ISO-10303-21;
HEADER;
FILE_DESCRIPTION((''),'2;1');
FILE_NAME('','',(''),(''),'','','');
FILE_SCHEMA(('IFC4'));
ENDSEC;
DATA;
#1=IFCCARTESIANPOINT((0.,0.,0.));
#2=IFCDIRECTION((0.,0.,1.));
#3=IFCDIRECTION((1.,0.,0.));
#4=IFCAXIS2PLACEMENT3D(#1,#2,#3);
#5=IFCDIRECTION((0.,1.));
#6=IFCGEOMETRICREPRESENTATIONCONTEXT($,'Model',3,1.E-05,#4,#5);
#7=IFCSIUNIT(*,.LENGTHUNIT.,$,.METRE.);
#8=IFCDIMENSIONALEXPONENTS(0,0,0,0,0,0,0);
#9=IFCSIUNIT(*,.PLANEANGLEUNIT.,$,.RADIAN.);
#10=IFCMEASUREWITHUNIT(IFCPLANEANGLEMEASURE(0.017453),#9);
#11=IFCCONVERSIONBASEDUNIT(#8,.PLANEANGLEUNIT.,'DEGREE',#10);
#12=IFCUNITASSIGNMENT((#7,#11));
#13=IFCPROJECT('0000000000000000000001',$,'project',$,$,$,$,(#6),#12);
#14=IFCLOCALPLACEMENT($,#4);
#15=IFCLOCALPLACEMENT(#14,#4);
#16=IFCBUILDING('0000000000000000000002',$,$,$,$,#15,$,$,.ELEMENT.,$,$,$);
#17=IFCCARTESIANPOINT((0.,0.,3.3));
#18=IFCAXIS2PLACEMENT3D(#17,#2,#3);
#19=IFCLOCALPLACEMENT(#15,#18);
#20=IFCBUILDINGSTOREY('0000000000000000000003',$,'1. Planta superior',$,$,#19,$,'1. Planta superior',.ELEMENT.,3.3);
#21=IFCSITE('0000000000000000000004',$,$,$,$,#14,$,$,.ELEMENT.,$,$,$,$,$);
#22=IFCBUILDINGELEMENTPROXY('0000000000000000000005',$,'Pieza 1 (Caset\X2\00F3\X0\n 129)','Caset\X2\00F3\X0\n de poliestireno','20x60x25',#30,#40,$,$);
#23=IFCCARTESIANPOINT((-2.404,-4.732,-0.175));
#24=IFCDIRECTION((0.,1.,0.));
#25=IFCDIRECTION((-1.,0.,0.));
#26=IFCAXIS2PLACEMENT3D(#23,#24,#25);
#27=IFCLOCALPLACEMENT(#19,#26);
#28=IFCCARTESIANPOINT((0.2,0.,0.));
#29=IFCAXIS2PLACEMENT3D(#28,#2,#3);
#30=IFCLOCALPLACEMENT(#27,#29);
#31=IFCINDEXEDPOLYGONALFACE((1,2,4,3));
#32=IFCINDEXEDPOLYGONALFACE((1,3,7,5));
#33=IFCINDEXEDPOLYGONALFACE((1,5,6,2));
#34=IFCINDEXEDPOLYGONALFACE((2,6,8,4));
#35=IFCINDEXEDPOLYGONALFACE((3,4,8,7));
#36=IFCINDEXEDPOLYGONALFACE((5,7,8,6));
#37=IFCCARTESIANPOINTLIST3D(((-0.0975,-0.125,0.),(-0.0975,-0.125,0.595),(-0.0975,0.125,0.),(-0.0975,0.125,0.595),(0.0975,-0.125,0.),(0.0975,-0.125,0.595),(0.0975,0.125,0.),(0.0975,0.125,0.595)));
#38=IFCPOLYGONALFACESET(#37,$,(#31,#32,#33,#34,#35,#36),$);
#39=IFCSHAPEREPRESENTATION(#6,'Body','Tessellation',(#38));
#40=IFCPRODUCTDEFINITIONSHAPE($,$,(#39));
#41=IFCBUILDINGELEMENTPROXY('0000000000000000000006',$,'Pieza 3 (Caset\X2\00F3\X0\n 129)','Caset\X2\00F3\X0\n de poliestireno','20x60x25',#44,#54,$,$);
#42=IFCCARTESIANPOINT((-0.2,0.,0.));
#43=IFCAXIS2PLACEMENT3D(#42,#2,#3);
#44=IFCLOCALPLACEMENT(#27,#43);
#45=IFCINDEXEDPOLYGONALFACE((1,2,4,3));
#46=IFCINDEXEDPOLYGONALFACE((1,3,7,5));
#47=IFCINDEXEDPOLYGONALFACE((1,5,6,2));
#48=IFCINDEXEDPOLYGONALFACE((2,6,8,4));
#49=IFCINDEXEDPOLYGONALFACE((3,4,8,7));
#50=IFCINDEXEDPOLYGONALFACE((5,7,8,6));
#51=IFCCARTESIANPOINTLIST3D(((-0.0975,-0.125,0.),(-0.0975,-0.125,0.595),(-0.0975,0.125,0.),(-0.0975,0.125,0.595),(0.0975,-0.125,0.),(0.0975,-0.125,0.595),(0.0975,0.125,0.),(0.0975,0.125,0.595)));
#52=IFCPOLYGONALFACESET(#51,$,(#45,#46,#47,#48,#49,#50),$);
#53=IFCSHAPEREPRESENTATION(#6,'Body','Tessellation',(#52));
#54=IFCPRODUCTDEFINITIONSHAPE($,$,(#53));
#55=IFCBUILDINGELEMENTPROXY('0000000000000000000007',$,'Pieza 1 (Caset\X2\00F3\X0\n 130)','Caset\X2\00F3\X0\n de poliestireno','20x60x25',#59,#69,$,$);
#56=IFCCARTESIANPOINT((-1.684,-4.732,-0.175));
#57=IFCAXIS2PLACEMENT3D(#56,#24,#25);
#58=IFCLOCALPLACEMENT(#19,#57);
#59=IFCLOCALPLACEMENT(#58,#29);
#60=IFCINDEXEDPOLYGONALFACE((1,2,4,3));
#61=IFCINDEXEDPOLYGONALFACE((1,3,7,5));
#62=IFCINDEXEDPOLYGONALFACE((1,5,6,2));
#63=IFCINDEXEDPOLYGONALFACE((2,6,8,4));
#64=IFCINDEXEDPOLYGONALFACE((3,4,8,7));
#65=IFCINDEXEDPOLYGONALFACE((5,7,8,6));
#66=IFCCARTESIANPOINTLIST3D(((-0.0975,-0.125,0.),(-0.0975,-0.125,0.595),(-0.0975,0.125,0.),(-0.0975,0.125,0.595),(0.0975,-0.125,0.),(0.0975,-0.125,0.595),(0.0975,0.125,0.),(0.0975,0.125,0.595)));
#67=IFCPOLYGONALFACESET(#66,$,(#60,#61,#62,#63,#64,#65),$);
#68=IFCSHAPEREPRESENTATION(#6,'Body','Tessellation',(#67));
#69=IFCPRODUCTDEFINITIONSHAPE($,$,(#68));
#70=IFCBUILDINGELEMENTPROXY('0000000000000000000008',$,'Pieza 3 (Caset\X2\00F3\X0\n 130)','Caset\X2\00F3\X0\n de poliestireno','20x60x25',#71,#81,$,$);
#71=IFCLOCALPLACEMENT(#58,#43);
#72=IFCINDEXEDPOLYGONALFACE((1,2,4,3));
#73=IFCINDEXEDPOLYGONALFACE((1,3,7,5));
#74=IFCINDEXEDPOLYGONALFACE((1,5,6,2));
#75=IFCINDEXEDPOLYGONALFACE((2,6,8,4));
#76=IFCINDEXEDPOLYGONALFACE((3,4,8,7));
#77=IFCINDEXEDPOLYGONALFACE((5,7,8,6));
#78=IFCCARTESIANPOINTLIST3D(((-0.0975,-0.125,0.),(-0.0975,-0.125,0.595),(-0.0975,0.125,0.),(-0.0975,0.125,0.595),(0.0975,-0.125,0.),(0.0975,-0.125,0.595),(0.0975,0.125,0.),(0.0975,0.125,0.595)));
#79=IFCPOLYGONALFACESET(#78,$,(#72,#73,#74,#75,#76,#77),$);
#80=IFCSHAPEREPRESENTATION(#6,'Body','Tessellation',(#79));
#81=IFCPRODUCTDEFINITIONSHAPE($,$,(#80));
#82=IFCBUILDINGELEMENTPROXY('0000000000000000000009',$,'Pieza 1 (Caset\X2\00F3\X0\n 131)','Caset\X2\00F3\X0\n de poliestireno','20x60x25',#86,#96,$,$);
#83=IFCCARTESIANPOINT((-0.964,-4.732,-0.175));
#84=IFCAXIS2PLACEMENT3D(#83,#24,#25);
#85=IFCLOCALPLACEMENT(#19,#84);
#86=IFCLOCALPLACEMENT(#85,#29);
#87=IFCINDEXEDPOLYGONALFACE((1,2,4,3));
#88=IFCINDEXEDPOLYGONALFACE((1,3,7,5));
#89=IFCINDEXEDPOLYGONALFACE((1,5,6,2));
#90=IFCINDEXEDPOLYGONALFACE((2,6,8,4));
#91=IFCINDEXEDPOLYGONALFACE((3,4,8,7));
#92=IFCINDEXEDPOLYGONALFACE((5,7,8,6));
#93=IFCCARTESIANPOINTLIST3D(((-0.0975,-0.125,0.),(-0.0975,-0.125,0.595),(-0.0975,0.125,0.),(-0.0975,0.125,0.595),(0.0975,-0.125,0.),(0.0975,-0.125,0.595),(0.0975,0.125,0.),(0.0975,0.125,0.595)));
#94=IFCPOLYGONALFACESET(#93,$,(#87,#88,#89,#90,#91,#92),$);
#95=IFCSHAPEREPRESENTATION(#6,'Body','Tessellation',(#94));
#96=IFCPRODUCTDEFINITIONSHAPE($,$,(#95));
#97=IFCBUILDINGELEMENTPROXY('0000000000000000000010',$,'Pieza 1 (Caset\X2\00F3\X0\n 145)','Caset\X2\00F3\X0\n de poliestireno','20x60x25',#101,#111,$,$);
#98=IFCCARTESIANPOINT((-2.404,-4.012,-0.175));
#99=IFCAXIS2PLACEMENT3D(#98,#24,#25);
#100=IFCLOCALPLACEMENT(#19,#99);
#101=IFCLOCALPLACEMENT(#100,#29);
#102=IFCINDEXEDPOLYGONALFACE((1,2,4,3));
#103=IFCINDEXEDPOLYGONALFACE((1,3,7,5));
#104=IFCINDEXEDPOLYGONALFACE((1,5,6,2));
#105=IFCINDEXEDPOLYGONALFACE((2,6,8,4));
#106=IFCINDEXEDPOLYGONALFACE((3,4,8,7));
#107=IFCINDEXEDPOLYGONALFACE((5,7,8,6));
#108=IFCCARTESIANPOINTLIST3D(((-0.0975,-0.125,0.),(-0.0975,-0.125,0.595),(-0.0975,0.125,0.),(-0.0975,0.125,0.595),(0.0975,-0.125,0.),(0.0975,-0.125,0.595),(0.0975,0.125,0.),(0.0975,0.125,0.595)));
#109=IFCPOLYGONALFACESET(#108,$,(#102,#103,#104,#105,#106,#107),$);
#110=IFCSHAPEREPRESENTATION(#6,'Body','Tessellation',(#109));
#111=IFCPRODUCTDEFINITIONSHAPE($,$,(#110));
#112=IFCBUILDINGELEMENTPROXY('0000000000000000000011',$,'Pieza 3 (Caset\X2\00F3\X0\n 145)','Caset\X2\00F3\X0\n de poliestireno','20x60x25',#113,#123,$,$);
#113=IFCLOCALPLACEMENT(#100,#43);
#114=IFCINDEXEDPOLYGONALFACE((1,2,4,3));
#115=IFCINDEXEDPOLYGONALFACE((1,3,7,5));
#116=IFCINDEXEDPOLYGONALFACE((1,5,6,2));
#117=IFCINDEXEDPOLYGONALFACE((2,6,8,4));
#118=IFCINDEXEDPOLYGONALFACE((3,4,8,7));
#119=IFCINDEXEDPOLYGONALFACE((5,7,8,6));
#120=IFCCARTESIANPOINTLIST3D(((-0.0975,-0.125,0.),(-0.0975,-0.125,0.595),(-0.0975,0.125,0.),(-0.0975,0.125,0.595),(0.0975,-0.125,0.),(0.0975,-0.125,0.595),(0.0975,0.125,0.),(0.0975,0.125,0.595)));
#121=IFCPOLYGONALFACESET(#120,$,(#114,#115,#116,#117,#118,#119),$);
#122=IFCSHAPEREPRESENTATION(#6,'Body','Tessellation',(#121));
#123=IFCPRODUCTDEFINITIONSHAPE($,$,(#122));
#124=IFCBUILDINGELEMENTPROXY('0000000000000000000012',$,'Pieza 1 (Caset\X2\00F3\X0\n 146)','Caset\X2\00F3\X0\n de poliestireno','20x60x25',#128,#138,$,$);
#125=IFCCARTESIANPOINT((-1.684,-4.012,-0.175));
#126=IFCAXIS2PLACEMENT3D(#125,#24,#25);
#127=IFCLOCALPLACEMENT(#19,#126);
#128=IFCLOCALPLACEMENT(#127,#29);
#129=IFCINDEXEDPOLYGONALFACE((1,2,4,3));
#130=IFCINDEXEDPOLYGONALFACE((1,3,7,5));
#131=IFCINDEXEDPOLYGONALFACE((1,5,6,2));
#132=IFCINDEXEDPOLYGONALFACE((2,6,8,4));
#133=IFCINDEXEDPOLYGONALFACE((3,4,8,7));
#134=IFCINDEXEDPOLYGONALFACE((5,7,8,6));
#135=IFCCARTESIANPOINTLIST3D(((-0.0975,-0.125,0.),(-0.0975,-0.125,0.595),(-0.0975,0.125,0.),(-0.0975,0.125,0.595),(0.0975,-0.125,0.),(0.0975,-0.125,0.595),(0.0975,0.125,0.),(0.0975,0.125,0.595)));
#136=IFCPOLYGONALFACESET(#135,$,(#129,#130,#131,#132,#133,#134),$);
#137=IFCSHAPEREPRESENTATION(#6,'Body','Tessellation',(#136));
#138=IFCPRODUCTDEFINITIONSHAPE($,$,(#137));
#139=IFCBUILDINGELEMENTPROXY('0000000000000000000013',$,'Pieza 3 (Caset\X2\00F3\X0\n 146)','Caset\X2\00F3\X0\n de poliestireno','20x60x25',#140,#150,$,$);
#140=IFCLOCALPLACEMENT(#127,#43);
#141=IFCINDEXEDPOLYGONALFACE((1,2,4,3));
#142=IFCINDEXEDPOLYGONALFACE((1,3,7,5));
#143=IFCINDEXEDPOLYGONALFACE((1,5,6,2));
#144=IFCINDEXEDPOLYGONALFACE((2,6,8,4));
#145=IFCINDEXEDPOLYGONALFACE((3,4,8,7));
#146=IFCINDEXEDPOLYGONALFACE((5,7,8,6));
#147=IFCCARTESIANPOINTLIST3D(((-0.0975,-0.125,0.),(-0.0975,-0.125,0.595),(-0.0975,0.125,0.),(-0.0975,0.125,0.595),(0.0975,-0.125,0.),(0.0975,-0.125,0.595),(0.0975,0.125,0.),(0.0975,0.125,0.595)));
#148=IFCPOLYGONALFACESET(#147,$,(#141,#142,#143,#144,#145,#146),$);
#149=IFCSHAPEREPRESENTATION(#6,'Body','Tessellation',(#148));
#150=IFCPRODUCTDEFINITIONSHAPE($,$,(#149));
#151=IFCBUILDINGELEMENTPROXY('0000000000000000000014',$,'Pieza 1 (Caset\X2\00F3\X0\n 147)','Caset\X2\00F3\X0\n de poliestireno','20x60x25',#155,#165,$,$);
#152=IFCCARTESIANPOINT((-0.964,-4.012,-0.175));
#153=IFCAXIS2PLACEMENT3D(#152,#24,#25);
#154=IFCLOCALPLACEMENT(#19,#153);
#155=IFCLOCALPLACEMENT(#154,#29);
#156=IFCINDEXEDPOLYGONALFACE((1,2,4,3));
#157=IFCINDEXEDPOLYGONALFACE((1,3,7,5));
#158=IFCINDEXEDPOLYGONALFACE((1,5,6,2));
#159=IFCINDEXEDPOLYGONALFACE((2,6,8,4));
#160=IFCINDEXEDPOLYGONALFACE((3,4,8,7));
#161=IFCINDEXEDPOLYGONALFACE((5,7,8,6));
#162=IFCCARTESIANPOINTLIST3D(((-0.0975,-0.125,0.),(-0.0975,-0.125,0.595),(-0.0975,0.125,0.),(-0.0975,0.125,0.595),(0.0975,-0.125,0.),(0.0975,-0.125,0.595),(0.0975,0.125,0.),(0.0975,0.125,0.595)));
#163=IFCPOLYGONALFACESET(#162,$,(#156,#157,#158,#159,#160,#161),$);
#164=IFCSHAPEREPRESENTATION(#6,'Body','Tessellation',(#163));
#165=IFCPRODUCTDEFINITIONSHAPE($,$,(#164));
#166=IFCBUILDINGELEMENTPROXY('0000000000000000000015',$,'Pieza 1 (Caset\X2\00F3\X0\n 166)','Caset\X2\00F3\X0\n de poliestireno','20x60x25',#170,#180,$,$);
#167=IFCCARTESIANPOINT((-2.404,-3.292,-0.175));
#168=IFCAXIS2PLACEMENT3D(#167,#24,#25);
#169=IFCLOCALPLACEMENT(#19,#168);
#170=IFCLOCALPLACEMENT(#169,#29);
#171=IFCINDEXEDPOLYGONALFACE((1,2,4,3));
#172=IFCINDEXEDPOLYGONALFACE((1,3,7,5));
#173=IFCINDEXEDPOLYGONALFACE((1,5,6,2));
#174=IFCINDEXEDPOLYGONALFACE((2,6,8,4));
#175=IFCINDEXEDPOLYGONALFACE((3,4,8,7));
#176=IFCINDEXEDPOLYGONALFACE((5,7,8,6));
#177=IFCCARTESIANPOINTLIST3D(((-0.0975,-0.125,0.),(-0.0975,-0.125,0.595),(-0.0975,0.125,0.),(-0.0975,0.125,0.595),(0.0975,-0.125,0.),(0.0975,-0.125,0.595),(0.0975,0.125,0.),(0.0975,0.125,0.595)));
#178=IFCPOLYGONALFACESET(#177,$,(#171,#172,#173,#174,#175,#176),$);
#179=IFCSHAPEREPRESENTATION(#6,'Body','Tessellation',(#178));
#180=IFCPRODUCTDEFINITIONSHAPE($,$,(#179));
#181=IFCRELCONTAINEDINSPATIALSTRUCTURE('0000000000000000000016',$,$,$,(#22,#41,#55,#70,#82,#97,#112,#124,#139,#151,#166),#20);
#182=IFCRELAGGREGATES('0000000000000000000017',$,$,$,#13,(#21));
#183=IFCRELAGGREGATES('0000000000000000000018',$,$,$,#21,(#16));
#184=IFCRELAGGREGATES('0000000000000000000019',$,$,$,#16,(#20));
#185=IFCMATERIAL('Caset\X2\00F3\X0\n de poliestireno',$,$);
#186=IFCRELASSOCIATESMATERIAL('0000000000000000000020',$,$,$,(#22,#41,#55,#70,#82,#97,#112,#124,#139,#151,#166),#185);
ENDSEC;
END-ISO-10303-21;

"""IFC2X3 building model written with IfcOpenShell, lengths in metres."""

from ifc_helpers import new_model, entity, si_unit, converted_unit, direction, frame, origin_with_axes, origin_2d_with_axis, place, context, project, spatial, rectangle, extrude, source, transform, mapped, material, element, save


model = new_model("IFC2X3")

# Units and contexts
model_context = context("Model", 3, precision=1e-05, world=origin_with_axes(), true_north=direction((0.0, 1.0)))
ifc_project = project(units=[si_unit("LENGTHUNIT", "METRE"), converted_unit("PLANEANGLEUNIT", "DEGREE", entity("IfcPlaneAngleMeasure", 0.017453), si_unit("PLANEANGLEUNIT", "RADIAN"), dimensions=[0, 0, 0, 0, 0, 0, 0])], contexts=[model_context])

# Site, building, storey
site_placement = place(None, origin_with_axes())
site = spatial("IfcSite", under=ifc_project, at=site_placement, CompositionType="ELEMENT")
building_placement = place(site_placement, origin_with_axes())
building = spatial("IfcBuilding", under=site, at=building_placement, CompositionType="ELEMENT")
storey_placement = place(building_placement, frame((0.0, 0.0, 3.3), z_axis=(0.0, 0.0, 1.0), x_axis=(1.0, 0.0, 0.0)))
storey = spatial("IfcBuildingStorey", under=building, at=storey_placement, Name="1. Planta superior", LongName="1. Planta superior", CompositionType="ELEMENT", Elevation=3.3)

# Building element proxies
ifc_material = material(Name="Casetón de poliestireno")
shared_shape = source(origin_with_axes(), model_context, "Body", "SweptSolid", [
    extrude(rectangle(XDim=0.195, YDim=0.25, at=origin_2d_with_axis()), origin_with_axes(), (0.0, 0.0, 1.0), 0.595),
])
placement_1 = place(storey_placement, frame((-2.404, -4.732, -0.175), z_axis=(0.0, 1.0, 0.0), x_axis=(-1.0, 0.0, 0.0)))
for number, where, z_axis, x_axis, name in (
    (1, (0.2, 0.0, 0.0), (0.0, 0.0, 1.0), (1.0, 0.0, 0.0), "Pieza 1 (Casetón 129)"),
    (2, (-0.2, 0.0, 0.0), (0.0, 0.0, 1.0), (1.0, 0.0, 0.0), "Pieza 3 (Casetón 129)"),
):
    element("IfcBuildingElementProxy", number, at=place(placement_1, frame(where, z_axis=z_axis, x_axis=x_axis)), inside=storey, material=ifc_material, Name=name, Description="Casetón de poliestireno", ObjectType="20x60x25", context=model_context, shape_type="MappedRepresentation", body=[
        mapped(shared_shape, transform((0.0, 0.0, 0.0), x_axis=(1.0, 0.0, 0.0), y_axis=(0.0, 1.0, 0.0), z_axis=(0.0, 0.0, 1.0))),
    ])
placement_2 = place(storey_placement, frame((-1.684, -4.732, -0.175), z_axis=(0.0, 1.0, 0.0), x_axis=(-1.0, 0.0, 0.0)))
for number, where, z_axis, x_axis, name in (
    (3, (0.2, 0.0, 0.0), (0.0, 0.0, 1.0), (1.0, 0.0, 0.0), "Pieza 1 (Casetón 130)"),
    (4, (-0.2, 0.0, 0.0), (0.0, 0.0, 1.0), (1.0, 0.0, 0.0), "Pieza 3 (Casetón 130)"),
):
    element("IfcBuildingElementProxy", number, at=place(placement_2, frame(where, z_axis=z_axis, x_axis=x_axis)), inside=storey, material=ifc_material, Name=name, Description="Casetón de poliestireno", ObjectType="20x60x25", context=model_context, shape_type="MappedRepresentation", body=[
        mapped(shared_shape, transform((0.0, 0.0, 0.0), x_axis=(1.0, 0.0, 0.0), y_axis=(0.0, 1.0, 0.0), z_axis=(0.0, 0.0, 1.0))),
    ])
placement_3 = place(storey_placement, frame((-0.964, -4.732, -0.175), z_axis=(0.0, 1.0, 0.0), x_axis=(-1.0, 0.0, 0.0)))
for number, where, z_axis, x_axis, name in (
    (5, (0.2, 0.0, 0.0), (0.0, 0.0, 1.0), (1.0, 0.0, 0.0), "Pieza 1 (Casetón 131)"),
):
    element("IfcBuildingElementProxy", number, at=place(placement_3, frame(where, z_axis=z_axis, x_axis=x_axis)), inside=storey, material=ifc_material, Name=name, Description="Casetón de poliestireno", ObjectType="20x60x25", context=model_context, shape_type="MappedRepresentation", body=[
        mapped(shared_shape, transform((0.0, 0.0, 0.0), x_axis=(1.0, 0.0, 0.0), y_axis=(0.0, 1.0, 0.0), z_axis=(0.0, 0.0, 1.0))),
    ])
placement_4 = place(storey_placement, frame((-2.404, -4.012, -0.175), z_axis=(0.0, 1.0, 0.0), x_axis=(-1.0, 0.0, 0.0)))
for number, where, z_axis, x_axis, name in (
    (6, (0.2, 0.0, 0.0), (0.0, 0.0, 1.0), (1.0, 0.0, 0.0), "Pieza 1 (Casetón 145)"),
    (7, (-0.2, 0.0, 0.0), (0.0, 0.0, 1.0), (1.0, 0.0, 0.0), "Pieza 3 (Casetón 145)"),
):
    element("IfcBuildingElementProxy", number, at=place(placement_4, frame(where, z_axis=z_axis, x_axis=x_axis)), inside=storey, material=ifc_material, Name=name, Description="Casetón de poliestireno", ObjectType="20x60x25", context=model_context, shape_type="MappedRepresentation", body=[
        mapped(shared_shape, transform((0.0, 0.0, 0.0), x_axis=(1.0, 0.0, 0.0), y_axis=(0.0, 1.0, 0.0), z_axis=(0.0, 0.0, 1.0))),
    ])
placement_5 = place(storey_placement, frame((-1.684, -4.012, -0.175), z_axis=(0.0, 1.0, 0.0), x_axis=(-1.0, 0.0, 0.0)))
for number, where, z_axis, x_axis, name in (
    (8, (0.2, 0.0, 0.0), (0.0, 0.0, 1.0), (1.0, 0.0, 0.0), "Pieza 1 (Casetón 146)"),
    (9, (-0.2, 0.0, 0.0), (0.0, 0.0, 1.0), (1.0, 0.0, 0.0), "Pieza 3 (Casetón 146)"),
):
    element("IfcBuildingElementProxy", number, at=place(placement_5, frame(where, z_axis=z_axis, x_axis=x_axis)), inside=storey, material=ifc_material, Name=name, Description="Casetón de poliestireno", ObjectType="20x60x25", context=model_context, shape_type="MappedRepresentation", body=[
        mapped(shared_shape, transform((0.0, 0.0, 0.0), x_axis=(1.0, 0.0, 0.0), y_axis=(0.0, 1.0, 0.0), z_axis=(0.0, 0.0, 1.0))),
    ])
placement_6 = place(storey_placement, frame((-0.964, -4.012, -0.175), z_axis=(0.0, 1.0, 0.0), x_axis=(-1.0, 0.0, 0.0)))
for number, where, z_axis, x_axis, name in (
    (10, (0.2, 0.0, 0.0), (0.0, 0.0, 1.0), (1.0, 0.0, 0.0), "Pieza 1 (Casetón 147)"),
):
    element("IfcBuildingElementProxy", number, at=place(placement_6, frame(where, z_axis=z_axis, x_axis=x_axis)), inside=storey, material=ifc_material, Name=name, Description="Casetón de poliestireno", ObjectType="20x60x25", context=model_context, shape_type="MappedRepresentation", body=[
        mapped(shared_shape, transform((0.0, 0.0, 0.0), x_axis=(1.0, 0.0, 0.0), y_axis=(0.0, 1.0, 0.0), z_axis=(0.0, 0.0, 1.0))),
    ])
placement_7 = place(storey_placement, frame((-2.404, -3.292, -0.175), z_axis=(0.0, 1.0, 0.0), x_axis=(-1.0, 0.0, 0.0)))
for number, where, z_axis, x_axis, name in (
    (11, (0.2, 0.0, 0.0), (0.0, 0.0, 1.0), (1.0, 0.0, 0.0), "Pieza 1 (Casetón 166)"),
):
    element("IfcBuildingElementProxy", number, at=place(placement_7, frame(where, z_axis=z_axis, x_axis=x_axis)), inside=storey, material=ifc_material, Name=name, Description="Casetón de poliestireno", ObjectType="20x60x25", context=model_context, shape_type="MappedRepresentation", body=[
        mapped(shared_shape, transform((0.0, 0.0, 0.0), x_axis=(1.0, 0.0, 0.0), y_axis=(0.0, 1.0, 0.0), z_axis=(0.0, 0.0, 1.0))),
    ])

save(model, "model.ifc")
